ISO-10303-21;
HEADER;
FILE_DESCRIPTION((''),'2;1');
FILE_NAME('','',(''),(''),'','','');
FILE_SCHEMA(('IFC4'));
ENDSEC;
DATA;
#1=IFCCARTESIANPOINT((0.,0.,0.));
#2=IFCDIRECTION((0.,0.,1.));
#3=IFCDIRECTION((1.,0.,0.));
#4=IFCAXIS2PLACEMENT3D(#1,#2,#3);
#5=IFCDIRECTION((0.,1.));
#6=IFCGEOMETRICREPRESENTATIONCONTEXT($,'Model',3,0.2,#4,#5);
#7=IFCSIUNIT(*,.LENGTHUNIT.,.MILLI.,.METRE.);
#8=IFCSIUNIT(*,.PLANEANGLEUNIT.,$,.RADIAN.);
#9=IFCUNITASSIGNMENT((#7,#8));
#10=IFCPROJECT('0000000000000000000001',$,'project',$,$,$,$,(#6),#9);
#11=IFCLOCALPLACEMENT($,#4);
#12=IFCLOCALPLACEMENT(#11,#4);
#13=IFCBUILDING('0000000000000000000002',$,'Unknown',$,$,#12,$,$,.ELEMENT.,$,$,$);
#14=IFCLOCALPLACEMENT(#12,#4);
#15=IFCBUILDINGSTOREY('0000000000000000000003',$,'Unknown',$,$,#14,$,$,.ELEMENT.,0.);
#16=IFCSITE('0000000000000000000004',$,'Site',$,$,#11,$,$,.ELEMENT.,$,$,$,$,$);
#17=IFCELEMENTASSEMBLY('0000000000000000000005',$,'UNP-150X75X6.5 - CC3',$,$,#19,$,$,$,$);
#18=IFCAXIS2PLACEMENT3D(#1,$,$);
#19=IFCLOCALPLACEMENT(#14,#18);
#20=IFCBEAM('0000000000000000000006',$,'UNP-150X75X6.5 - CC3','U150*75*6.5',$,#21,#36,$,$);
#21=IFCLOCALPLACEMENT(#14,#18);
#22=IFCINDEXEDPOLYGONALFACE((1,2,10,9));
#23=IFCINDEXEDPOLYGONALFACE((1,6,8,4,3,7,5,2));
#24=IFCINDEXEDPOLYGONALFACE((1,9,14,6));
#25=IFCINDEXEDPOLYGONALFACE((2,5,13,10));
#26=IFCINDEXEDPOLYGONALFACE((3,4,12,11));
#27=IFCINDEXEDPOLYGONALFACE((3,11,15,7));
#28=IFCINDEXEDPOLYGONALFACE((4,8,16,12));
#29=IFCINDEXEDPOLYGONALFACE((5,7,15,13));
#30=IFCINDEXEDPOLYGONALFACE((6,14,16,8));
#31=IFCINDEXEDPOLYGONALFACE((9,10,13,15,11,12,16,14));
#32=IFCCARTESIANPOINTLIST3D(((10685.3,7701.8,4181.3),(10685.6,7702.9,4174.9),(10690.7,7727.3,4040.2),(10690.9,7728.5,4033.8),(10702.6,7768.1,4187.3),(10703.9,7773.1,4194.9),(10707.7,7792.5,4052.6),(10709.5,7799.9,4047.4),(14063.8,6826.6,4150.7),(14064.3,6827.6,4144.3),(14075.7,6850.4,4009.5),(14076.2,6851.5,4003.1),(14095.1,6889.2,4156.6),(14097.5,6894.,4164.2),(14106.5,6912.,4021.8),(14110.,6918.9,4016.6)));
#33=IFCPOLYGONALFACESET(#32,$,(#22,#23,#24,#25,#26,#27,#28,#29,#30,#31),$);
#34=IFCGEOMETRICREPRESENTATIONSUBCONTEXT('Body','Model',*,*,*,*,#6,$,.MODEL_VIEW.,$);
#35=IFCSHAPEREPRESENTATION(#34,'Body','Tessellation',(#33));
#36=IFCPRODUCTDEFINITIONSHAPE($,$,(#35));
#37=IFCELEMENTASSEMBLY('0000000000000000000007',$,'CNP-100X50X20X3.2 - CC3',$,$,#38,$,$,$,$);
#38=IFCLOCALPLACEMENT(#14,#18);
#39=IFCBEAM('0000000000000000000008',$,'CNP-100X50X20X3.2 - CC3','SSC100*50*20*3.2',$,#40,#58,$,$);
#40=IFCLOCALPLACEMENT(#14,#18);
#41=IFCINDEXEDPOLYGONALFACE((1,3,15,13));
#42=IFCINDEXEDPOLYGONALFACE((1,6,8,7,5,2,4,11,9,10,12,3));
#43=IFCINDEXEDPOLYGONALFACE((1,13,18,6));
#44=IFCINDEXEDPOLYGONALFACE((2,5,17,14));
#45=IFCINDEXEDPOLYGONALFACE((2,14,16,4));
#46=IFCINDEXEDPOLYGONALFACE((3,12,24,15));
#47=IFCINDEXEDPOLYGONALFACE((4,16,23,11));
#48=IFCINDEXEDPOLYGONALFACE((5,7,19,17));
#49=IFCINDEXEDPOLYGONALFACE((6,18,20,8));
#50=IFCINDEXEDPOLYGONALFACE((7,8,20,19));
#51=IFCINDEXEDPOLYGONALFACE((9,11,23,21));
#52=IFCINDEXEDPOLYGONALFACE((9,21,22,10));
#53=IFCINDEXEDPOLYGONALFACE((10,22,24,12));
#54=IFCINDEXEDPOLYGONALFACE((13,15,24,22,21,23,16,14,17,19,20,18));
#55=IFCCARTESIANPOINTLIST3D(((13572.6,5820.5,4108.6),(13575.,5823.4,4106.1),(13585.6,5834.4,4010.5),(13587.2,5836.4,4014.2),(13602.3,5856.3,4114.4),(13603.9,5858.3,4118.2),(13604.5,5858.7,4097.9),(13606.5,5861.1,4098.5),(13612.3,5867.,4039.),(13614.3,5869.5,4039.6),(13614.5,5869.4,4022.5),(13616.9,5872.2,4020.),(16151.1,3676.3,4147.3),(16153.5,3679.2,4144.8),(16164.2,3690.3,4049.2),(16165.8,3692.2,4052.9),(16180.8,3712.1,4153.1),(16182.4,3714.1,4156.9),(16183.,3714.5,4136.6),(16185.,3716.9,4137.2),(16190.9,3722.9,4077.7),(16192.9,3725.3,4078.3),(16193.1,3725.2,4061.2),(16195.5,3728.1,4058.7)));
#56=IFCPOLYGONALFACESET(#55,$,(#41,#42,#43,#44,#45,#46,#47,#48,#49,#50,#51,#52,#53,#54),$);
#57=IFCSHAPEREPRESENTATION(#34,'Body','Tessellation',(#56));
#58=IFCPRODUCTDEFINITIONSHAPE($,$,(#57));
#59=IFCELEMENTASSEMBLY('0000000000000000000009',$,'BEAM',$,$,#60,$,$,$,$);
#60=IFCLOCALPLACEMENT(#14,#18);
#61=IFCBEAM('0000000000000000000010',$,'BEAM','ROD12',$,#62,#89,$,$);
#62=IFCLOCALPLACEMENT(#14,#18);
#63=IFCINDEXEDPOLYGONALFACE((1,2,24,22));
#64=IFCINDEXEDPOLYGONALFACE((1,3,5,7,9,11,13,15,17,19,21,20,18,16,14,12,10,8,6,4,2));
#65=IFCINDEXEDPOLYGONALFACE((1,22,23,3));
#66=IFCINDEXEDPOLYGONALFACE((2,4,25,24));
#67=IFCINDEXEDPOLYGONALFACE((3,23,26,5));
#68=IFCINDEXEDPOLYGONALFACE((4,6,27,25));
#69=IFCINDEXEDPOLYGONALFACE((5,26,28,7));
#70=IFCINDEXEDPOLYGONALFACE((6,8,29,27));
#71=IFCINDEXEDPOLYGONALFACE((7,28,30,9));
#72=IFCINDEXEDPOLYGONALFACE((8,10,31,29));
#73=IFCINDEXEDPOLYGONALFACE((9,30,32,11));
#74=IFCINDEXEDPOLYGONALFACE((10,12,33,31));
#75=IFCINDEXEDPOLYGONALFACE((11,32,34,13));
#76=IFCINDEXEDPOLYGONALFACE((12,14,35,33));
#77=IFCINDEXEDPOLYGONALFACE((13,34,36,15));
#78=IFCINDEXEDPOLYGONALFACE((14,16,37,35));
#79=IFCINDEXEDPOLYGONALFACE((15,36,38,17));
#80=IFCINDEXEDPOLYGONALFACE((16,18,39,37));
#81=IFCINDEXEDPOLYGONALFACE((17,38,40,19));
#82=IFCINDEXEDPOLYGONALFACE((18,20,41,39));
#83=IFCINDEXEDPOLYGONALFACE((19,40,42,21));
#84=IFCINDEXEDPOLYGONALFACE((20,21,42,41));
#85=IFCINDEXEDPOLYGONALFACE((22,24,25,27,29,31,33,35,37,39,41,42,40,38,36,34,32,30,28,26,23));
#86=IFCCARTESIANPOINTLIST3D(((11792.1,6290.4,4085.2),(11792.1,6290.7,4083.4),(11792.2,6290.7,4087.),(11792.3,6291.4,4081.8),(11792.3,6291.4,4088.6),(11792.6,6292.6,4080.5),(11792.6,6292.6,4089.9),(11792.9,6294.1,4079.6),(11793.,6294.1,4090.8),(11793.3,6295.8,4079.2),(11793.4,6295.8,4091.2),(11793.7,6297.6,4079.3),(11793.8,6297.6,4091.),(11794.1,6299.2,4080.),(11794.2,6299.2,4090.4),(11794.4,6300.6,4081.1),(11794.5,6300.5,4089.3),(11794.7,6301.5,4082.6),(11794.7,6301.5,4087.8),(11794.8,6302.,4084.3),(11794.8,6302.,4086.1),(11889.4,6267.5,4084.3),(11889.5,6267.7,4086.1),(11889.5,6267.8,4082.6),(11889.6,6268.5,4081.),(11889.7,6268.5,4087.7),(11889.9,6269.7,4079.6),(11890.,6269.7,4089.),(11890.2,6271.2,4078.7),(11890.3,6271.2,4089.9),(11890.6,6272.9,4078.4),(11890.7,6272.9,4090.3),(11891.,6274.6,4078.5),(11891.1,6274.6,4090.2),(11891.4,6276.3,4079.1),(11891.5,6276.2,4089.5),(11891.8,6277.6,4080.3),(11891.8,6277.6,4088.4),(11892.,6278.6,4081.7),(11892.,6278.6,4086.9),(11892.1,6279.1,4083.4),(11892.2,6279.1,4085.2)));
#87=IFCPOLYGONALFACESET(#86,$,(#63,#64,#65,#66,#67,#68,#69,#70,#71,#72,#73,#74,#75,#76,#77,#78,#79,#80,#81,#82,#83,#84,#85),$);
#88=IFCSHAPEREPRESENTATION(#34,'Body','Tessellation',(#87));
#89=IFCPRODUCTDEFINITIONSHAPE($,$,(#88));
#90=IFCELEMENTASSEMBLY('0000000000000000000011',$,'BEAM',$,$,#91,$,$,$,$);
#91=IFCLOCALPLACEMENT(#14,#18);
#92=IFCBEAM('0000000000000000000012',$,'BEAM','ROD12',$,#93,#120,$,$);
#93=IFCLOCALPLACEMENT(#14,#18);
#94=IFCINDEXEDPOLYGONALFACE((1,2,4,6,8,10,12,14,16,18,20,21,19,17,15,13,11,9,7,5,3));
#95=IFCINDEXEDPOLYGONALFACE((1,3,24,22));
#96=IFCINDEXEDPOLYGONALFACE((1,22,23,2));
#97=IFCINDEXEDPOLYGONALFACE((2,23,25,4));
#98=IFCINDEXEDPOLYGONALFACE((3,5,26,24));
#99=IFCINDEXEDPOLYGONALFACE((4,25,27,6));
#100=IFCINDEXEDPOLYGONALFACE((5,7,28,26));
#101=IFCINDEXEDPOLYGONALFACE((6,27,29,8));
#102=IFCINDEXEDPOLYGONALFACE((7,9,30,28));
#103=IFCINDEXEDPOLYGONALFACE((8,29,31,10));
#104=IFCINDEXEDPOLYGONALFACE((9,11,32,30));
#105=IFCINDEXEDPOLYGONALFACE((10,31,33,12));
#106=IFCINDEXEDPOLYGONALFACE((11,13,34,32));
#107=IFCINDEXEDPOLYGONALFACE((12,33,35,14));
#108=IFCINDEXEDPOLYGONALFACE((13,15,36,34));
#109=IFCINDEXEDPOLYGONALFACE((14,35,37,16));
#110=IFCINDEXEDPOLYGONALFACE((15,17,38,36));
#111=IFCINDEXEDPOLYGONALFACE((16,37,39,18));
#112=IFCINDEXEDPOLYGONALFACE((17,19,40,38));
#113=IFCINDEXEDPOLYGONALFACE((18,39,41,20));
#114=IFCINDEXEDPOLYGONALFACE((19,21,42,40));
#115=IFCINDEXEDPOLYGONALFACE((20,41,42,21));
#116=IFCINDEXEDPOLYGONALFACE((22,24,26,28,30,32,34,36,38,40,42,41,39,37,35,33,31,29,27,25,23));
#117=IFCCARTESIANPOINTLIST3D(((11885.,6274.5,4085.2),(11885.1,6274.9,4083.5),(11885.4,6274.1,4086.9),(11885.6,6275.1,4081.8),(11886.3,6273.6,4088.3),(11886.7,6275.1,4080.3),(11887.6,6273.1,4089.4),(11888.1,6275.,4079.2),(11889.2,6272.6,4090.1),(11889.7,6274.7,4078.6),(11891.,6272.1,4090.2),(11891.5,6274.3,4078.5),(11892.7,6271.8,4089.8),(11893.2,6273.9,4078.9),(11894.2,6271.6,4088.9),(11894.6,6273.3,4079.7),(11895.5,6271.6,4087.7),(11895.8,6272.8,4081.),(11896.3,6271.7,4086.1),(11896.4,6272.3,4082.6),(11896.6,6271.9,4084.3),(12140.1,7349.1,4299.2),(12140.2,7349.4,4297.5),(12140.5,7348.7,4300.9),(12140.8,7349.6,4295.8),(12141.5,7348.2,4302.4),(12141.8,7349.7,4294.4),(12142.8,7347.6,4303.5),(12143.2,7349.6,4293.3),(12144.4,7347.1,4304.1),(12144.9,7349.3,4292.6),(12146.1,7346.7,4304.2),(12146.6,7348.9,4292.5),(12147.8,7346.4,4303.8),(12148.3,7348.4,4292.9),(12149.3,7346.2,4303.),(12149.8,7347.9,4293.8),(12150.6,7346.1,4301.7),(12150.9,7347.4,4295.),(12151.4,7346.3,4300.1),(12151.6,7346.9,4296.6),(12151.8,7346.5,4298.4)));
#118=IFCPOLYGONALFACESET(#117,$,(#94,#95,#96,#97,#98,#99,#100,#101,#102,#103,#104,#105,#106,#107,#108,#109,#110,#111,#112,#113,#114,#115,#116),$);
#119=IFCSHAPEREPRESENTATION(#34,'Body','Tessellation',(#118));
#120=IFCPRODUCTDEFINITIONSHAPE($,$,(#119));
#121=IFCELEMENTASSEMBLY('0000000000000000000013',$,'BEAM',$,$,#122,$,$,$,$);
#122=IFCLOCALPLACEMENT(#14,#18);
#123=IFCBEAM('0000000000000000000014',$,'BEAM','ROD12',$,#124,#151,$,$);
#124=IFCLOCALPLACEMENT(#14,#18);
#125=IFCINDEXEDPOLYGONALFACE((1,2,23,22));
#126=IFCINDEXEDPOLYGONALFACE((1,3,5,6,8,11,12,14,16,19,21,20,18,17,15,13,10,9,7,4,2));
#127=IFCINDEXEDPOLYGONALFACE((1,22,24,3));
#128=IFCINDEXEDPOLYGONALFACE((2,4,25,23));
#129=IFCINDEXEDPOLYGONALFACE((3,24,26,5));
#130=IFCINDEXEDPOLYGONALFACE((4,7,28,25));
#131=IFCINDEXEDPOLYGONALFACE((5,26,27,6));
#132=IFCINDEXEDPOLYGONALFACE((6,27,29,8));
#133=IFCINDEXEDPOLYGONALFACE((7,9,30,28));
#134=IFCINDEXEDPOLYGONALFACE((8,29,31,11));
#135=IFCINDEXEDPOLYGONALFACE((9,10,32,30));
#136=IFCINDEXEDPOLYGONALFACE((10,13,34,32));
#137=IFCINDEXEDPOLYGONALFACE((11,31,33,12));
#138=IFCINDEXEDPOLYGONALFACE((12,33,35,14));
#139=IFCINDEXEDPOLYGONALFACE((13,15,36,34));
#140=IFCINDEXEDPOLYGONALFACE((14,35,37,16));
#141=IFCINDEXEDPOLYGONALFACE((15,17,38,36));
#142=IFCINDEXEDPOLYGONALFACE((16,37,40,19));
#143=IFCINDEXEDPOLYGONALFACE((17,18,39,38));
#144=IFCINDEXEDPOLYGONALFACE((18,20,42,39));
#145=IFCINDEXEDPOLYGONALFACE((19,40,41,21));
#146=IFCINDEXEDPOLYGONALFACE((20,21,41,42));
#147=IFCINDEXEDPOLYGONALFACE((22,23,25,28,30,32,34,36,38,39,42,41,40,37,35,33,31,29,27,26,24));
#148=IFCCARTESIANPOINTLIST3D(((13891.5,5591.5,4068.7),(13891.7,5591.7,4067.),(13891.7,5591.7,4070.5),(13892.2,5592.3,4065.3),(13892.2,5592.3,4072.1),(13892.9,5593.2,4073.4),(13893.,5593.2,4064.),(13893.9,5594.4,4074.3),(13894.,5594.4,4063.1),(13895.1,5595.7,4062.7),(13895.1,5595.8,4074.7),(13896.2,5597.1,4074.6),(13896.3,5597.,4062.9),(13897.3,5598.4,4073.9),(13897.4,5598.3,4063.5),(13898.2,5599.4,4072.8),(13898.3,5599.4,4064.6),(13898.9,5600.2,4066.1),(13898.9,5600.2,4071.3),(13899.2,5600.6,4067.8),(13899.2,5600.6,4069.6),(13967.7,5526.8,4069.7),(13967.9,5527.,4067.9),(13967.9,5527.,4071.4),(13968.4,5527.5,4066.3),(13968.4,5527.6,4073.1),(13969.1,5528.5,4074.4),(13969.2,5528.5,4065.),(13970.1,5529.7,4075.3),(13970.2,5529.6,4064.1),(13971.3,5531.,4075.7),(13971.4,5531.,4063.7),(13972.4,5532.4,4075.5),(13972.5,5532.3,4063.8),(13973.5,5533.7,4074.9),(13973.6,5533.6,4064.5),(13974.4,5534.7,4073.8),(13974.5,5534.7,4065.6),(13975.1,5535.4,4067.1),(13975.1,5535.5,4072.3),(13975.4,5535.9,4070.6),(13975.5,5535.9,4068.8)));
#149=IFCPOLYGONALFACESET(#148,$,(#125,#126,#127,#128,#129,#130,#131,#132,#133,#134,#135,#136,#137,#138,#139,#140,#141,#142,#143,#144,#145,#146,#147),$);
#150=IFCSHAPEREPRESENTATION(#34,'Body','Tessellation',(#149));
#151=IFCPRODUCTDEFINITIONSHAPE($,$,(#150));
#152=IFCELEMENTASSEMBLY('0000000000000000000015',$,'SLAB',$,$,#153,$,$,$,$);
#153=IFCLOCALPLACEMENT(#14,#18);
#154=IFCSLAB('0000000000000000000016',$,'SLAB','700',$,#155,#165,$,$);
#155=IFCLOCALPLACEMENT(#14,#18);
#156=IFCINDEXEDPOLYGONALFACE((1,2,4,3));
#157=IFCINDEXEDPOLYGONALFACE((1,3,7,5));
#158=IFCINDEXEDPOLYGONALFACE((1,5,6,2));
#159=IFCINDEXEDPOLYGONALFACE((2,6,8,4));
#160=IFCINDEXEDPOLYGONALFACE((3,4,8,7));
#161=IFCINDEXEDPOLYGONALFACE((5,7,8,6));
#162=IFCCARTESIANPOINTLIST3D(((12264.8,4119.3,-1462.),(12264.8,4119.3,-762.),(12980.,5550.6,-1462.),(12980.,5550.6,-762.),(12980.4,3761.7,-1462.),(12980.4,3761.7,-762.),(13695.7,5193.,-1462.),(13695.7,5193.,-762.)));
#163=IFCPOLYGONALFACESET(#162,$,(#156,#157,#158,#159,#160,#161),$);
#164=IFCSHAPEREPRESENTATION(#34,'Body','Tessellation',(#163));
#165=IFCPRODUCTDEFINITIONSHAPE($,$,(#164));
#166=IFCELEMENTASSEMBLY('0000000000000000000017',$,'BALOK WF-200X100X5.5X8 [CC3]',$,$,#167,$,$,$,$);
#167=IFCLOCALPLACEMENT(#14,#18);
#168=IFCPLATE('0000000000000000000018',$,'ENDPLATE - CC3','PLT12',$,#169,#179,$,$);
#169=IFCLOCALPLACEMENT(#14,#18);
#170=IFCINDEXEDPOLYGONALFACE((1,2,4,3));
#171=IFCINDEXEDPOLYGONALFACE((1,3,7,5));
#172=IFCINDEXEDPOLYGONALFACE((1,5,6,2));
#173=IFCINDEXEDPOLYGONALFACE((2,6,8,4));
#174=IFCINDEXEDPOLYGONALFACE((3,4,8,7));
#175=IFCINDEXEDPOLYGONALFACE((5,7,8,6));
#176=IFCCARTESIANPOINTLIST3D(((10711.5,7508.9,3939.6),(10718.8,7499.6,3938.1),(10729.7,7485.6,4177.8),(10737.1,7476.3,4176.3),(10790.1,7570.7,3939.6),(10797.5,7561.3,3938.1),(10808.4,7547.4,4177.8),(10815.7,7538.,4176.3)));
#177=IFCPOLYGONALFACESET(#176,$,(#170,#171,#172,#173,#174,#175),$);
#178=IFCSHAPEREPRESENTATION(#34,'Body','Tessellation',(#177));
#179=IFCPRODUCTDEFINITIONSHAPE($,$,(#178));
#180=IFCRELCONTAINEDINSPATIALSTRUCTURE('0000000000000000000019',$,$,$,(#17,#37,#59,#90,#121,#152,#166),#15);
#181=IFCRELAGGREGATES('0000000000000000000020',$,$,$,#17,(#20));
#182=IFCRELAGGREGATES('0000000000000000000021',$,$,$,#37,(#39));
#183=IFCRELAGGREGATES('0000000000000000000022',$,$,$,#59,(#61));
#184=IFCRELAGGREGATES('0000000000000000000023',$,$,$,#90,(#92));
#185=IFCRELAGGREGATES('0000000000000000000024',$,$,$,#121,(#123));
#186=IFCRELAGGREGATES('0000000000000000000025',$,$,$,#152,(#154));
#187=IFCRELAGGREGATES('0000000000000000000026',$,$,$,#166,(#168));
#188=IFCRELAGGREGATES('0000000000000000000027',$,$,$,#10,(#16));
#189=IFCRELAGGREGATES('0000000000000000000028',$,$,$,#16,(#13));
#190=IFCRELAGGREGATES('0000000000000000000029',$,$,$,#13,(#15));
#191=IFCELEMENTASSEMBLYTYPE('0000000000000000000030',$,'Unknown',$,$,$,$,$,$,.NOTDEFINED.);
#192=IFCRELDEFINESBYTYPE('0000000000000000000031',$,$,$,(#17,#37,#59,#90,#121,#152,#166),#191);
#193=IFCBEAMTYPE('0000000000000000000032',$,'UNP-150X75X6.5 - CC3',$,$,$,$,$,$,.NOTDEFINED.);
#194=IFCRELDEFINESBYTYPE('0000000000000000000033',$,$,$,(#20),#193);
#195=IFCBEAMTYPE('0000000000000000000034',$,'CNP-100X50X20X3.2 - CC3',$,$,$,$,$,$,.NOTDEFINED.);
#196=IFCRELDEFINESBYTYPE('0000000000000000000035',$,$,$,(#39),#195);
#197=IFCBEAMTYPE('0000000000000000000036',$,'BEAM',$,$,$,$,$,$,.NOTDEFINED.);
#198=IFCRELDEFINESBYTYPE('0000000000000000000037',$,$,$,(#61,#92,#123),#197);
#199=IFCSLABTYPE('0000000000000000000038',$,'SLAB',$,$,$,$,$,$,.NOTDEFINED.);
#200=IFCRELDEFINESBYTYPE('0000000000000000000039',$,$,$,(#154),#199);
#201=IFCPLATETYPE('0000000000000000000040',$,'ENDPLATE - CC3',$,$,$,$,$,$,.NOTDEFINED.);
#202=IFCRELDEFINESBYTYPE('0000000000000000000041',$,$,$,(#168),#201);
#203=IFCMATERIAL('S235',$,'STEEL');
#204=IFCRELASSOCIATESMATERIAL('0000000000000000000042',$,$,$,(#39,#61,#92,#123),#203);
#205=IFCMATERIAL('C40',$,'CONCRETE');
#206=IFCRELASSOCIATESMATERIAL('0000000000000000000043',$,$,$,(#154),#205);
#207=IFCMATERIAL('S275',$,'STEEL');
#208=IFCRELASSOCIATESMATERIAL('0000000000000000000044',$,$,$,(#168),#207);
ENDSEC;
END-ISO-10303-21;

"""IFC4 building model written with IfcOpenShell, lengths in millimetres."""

from ifc_helpers import new_model, si_unit, direction, frame, origin_with_axes, origin_2d_with_axis, place, context, subcontext, project, spatial, line, indexed_curve, circle, u_section, c_section, outline, extrude, clip, halfspace, material, material_profile, profile_set, profile_usage, type_object, element, aggregate, save


model = new_model("IFC4")

# Units and contexts
model_context = context("Model", 3, precision=0.2, world=origin_with_axes(), true_north=direction((0.0, 1.0)))
body_context = subcontext(model_context, "Body", "Model", "MODEL_VIEW")
ifc_project = project(units=[si_unit("LENGTHUNIT", "METRE", prefix="MILLI"), si_unit("PLANEANGLEUNIT", "RADIAN")], contexts=[model_context])

# Site, building, storey
site_placement = place(None, origin_with_axes())
site = spatial("IfcSite", under=ifc_project, at=site_placement, Name="Site", CompositionType="ELEMENT")
building_placement = place(site_placement, origin_with_axes())
building = spatial("IfcBuilding", under=site, at=building_placement, Name="Unknown", CompositionType="ELEMENT")
storey_placement = place(building_placement, origin_with_axes())
storey = spatial("IfcBuildingStorey", under=building, at=storey_placement, Name="Unknown", CompositionType="ELEMENT", Elevation=0.0)

# Shared definitions
element_assembly_type = type_object("IfcElementAssemblyType", Name="Unknown", PredefinedType="NOTDEFINED")

# Element assemblies, beams
assembly_1_placement = place(storey_placement, frame((10697.4, 7750.8, 4114.3), z_axis=(-0.248145, -0.951518, -0.181762), x_axis=(0.968007, -0.250772, -0.00876)))
assembly_1 = element("IfcElementAssembly", 1, at=assembly_1_placement, inside=storey, type_object=element_assembly_type, Name="UNP-150X75X6.5 - CC3")
beam_type_1 = type_object("IfcBeamType", Name="UNP-150X75X6.5 - CC3", PredefinedType="NOTDEFINED")
beam_1_placement = place(assembly_1_placement, origin_with_axes())
beam_1 = element("IfcBeam", 2, at=beam_1_placement, type_object=beam_type_1, Name="UNP-150X75X6.5 - CC3", Description="U150*75*6.5", context=body_context, shape_type="Clipping", body=[
    clip(extrude(u_section(Depth=150.0, FlangeWidth=75.0, WebThickness=6.5, FlangeThickness=6.5, at=origin_2d_with_axis()), frame((0.0, 0.0, 0.0), z_axis=(-1.0, 0.0, 0.0), x_axis=(0.0, 0.0, 1.0)), (0.0, 0.0, -1.0), 3513.0), halfspace(frame((3497.4, -75.3, 36.8), z_axis=(0.977873, 0.046418, 0.203986), x_axis=(0.203788, 0.009011, -0.978973)), False)),
])
aggregate(assembly_1, [beam_1])
beam_type_2 = type_object("IfcBeamType", Name="CNP-100X50X20X3.2 - CC3", PredefinedType="NOTDEFINED")
assembly_2_placement = place(storey_placement, frame((13594.7, 5846.4, 4064.3), z_axis=(0.625928, 0.756181, 0.190796), x_axis=(0.76885, -0.639325, 0.011536)))
assembly_2 = element("IfcElementAssembly", 3, at=assembly_2_placement, inside=storey, type_object=element_assembly_type, Name="CNP-100X50X20X3.2 - CC3")
ifc_material_1 = material(Name="S235", Category="STEEL")
ifc_material_profile_1 = material_profile(ifc_material_1, c_section(Depth=100.0, Width=50.0, WallThickness=3.2, Girth=20.0, at=origin_2d_with_axis()), Name="SSC100*50*20*3.2")
ifc_profile_set_1 = profile_set([ifc_material_profile_1])
ifc_profile_usage_1 = profile_usage(ifc_profile_set_1, cardinal=4)
beam_2_placement = place(assembly_2_placement, origin_with_axes())
beam_2 = element("IfcBeam", 4, at=beam_2_placement, type_object=beam_type_2, material=ifc_profile_usage_1, Name="CNP-100X50X20X3.2 - CC3", Description="SSC100*50*20*3.2", context=body_context, shape_type="SolidModel", body=[
    extrude(c_section(Depth=100.0, Width=50.0, WallThickness=3.2, Girth=20.0, at=origin_2d_with_axis()), frame((0.0, 0.0, 0.0), z_axis=(-1.0, 0.0, 0.0), x_axis=(0.0, 0.0, 1.0)), (0.0, 0.0, -1.0), 3353.8),
])
aggregate(assembly_2, [beam_2])
assembly_3_placement = place(storey_placement, frame((11793.5, 6296.3, 4085.2), z_axis=(-0.229376, -0.973338, 0.0), x_axis=(0.973302, -0.229367, -0.008594)))
assembly_3 = element("IfcElementAssembly", 5, at=assembly_3_placement, inside=storey, type_object=element_assembly_type, Name="BEAM")
ifc_material_profile_2 = material_profile(ifc_material_1, circle(Radius=6.0, at=origin_2d_with_axis()), Name="ROD12")
ifc_profile_set_2 = profile_set([ifc_material_profile_2])
ifc_profile_usage_2 = profile_usage(ifc_profile_set_2, cardinal=5)
beam_type_3 = type_object("IfcBeamType", Name="BEAM", PredefinedType="NOTDEFINED")
beam_3_placement = place(assembly_3_placement, origin_with_axes())
beam_3 = element("IfcBeam", 6, at=beam_3_placement, type_object=beam_type_3, material=ifc_profile_usage_2, Name="BEAM", Description="ROD12", context=body_context, shape_type="SolidModel", body=[
    extrude(circle(Radius=6.0, at=origin_2d_with_axis()), frame((0.0, 0.0, 0.0), z_axis=(-1.0, 0.0, 0.0), x_axis=(0.0, 0.0, 1.0)), (0.0, 0.0, -1.0), 100.0),
])
aggregate(assembly_3, [beam_3])
assembly_4_placement = place(storey_placement, frame((11890.8, 6273.3, 4084.3), z_axis=(0.972955, -0.230997, 0.0), x_axis=(0.226778, 0.955184, 0.190249)))
assembly_4 = element("IfcElementAssembly", 7, at=assembly_4_placement, inside=storey, type_object=element_assembly_type, Name="BEAM")
beam_4_placement = place(assembly_4_placement, origin_with_axes())
beam_4 = element("IfcBeam", 8, at=beam_4_placement, type_object=beam_type_3, material=ifc_profile_usage_2, Name="BEAM", Description="ROD12", context=body_context, shape_type="SolidModel", body=[
    extrude(circle(Radius=6.0, at=origin_2d_with_axis()), frame((0.0, 0.0, 0.0), z_axis=(-1.0, 0.0, 0.0), x_axis=(0.0, 0.0, 1.0)), (0.0, 0.0, -1.0), 1125.0),
])
aggregate(assembly_4, [beam_4])
assembly_5_placement = place(storey_placement, frame((13895.4, 5596.1, 4068.7), z_axis=(-0.647279, -0.762253, 0.0), x_axis=(0.762218, -0.64725, 0.009556)))
assembly_5 = element("IfcElementAssembly", 9, at=assembly_5_placement, inside=storey, type_object=element_assembly_type, Name="BEAM")
beam_5_placement = place(assembly_5_placement, origin_with_axes())
beam_5 = element("IfcBeam", 10, at=beam_5_placement, type_object=beam_type_3, material=ifc_profile_usage_2, Name="BEAM", Description="ROD12", context=body_context, shape_type="SolidModel", body=[
    extrude(circle(Radius=6.0, at=origin_2d_with_axis()), frame((0.0, 0.0, 0.0), z_axis=(-1.0, 0.0, 0.0), x_axis=(0.0, 0.0, 1.0)), (0.0, 0.0, -1.0), 100.0),
])
aggregate(assembly_5, [beam_5])

# Element assembly, slab
assembly_6_placement = place(storey_placement, frame((12980.0, 5550.6, -1112.0), z_axis=(0.0, 0.0, 1.0), x_axis=(-0.44701, -0.894529, 0.0)))
assembly_6 = element("IfcElementAssembly", 11, at=assembly_6_placement, inside=storey, type_object=element_assembly_type, Name="SLAB")
ifc_material_2 = material(Name="C40", Category="CONCRETE")
ifc_material_profile_3 = material_profile(ifc_material_2, outline(indexed_curve([(0.0, 0.0), (1600.0, 0.0), (1600.0, 800.0), (0.0, 800.0)], segments=[line(1, 2, 3, 4, 1)])), Name="700")
ifc_profile_set_3 = profile_set([ifc_material_profile_3])
ifc_profile_usage_3 = profile_usage(ifc_profile_set_3, cardinal=5)
slab_type = type_object("IfcSlabType", Name="SLAB", PredefinedType="NOTDEFINED")
slab_placement = place(assembly_6_placement, origin_with_axes())
slab = element("IfcSlab", 12, at=slab_placement, type_object=slab_type, material=ifc_profile_usage_3, Name="SLAB", Description="700", context=body_context, shape_type="SolidModel", body=[
    extrude(outline(indexed_curve([(0.0, 0.0), (1600.0, 0.0), (1600.0, 800.0), (0.0, 800.0)], segments=[line(1, 2, 3, 4, 1)])), frame((0.0, 0.0, 350.0), z_axis=(0.0, 0.0, 1.0), x_axis=(1.0, 0.0, 0.0)), (0.0, 0.0, -1.0), 700.0),
])
aggregate(assembly_6, [slab])

# Shared definitions
ifc_material_3 = material(Name="S275", Category="STEEL")

# Element assembly, plate
assembly_7_placement = place(storey_placement, frame((12830.8, 4889.5, 3641.9), z_axis=(0.786661, 0.617385, 0.0), x_axis=(-0.612675, 0.780659, 0.123291)))
assembly_7 = element("IfcElementAssembly", 13, at=assembly_7_placement, inside=storey, type_object=element_assembly_type, Name="BALOK WF-200X100X5.5X8 [CC3]")
ifc_material_profile_4 = material_profile(ifc_material_3, outline(indexed_curve([(0.0, 0.0), (100.0, 0.0), (100.0, 240.0), (0.0, 240.0)], segments=[line(1, 2, 3, 4, 1)])), Name="PLT12")
ifc_profile_set_4 = profile_set([ifc_material_profile_4])
ifc_profile_usage_4 = profile_usage(ifc_profile_set_4, cardinal=5)
plate_type_1 = type_object("IfcPlateType", Name="ENDPLATE - CC3", PredefinedType="NOTDEFINED")
plate_1_placement = place(assembly_7_placement, frame((3374.0, 120.0, 50.0), z_axis=(-1.0, 0.0, 0.0), x_axis=(0.0, 0.0, -1.0)))
plate_1 = element("IfcPlate", 14, at=plate_1_placement, type_object=plate_type_1, material=ifc_profile_usage_4, Name="ENDPLATE - CC3", Description="PLT12", context=body_context, shape_type="SolidModel", body=[
    extrude(outline(indexed_curve([(0.0, 0.0), (100.0, 0.0), (100.0, 240.0), (0.0, 240.0)], segments=[line(1, 2, 3, 4, 1)])), frame((0.0, 0.0, 6.0), z_axis=(0.0, 0.0, 1.0), x_axis=(1.0, 0.0, 0.0)), (0.0, 0.0, -1.0), 12.0),
])

aggregate(assembly_7, [plate_1])

save(model, "model.ifc")
